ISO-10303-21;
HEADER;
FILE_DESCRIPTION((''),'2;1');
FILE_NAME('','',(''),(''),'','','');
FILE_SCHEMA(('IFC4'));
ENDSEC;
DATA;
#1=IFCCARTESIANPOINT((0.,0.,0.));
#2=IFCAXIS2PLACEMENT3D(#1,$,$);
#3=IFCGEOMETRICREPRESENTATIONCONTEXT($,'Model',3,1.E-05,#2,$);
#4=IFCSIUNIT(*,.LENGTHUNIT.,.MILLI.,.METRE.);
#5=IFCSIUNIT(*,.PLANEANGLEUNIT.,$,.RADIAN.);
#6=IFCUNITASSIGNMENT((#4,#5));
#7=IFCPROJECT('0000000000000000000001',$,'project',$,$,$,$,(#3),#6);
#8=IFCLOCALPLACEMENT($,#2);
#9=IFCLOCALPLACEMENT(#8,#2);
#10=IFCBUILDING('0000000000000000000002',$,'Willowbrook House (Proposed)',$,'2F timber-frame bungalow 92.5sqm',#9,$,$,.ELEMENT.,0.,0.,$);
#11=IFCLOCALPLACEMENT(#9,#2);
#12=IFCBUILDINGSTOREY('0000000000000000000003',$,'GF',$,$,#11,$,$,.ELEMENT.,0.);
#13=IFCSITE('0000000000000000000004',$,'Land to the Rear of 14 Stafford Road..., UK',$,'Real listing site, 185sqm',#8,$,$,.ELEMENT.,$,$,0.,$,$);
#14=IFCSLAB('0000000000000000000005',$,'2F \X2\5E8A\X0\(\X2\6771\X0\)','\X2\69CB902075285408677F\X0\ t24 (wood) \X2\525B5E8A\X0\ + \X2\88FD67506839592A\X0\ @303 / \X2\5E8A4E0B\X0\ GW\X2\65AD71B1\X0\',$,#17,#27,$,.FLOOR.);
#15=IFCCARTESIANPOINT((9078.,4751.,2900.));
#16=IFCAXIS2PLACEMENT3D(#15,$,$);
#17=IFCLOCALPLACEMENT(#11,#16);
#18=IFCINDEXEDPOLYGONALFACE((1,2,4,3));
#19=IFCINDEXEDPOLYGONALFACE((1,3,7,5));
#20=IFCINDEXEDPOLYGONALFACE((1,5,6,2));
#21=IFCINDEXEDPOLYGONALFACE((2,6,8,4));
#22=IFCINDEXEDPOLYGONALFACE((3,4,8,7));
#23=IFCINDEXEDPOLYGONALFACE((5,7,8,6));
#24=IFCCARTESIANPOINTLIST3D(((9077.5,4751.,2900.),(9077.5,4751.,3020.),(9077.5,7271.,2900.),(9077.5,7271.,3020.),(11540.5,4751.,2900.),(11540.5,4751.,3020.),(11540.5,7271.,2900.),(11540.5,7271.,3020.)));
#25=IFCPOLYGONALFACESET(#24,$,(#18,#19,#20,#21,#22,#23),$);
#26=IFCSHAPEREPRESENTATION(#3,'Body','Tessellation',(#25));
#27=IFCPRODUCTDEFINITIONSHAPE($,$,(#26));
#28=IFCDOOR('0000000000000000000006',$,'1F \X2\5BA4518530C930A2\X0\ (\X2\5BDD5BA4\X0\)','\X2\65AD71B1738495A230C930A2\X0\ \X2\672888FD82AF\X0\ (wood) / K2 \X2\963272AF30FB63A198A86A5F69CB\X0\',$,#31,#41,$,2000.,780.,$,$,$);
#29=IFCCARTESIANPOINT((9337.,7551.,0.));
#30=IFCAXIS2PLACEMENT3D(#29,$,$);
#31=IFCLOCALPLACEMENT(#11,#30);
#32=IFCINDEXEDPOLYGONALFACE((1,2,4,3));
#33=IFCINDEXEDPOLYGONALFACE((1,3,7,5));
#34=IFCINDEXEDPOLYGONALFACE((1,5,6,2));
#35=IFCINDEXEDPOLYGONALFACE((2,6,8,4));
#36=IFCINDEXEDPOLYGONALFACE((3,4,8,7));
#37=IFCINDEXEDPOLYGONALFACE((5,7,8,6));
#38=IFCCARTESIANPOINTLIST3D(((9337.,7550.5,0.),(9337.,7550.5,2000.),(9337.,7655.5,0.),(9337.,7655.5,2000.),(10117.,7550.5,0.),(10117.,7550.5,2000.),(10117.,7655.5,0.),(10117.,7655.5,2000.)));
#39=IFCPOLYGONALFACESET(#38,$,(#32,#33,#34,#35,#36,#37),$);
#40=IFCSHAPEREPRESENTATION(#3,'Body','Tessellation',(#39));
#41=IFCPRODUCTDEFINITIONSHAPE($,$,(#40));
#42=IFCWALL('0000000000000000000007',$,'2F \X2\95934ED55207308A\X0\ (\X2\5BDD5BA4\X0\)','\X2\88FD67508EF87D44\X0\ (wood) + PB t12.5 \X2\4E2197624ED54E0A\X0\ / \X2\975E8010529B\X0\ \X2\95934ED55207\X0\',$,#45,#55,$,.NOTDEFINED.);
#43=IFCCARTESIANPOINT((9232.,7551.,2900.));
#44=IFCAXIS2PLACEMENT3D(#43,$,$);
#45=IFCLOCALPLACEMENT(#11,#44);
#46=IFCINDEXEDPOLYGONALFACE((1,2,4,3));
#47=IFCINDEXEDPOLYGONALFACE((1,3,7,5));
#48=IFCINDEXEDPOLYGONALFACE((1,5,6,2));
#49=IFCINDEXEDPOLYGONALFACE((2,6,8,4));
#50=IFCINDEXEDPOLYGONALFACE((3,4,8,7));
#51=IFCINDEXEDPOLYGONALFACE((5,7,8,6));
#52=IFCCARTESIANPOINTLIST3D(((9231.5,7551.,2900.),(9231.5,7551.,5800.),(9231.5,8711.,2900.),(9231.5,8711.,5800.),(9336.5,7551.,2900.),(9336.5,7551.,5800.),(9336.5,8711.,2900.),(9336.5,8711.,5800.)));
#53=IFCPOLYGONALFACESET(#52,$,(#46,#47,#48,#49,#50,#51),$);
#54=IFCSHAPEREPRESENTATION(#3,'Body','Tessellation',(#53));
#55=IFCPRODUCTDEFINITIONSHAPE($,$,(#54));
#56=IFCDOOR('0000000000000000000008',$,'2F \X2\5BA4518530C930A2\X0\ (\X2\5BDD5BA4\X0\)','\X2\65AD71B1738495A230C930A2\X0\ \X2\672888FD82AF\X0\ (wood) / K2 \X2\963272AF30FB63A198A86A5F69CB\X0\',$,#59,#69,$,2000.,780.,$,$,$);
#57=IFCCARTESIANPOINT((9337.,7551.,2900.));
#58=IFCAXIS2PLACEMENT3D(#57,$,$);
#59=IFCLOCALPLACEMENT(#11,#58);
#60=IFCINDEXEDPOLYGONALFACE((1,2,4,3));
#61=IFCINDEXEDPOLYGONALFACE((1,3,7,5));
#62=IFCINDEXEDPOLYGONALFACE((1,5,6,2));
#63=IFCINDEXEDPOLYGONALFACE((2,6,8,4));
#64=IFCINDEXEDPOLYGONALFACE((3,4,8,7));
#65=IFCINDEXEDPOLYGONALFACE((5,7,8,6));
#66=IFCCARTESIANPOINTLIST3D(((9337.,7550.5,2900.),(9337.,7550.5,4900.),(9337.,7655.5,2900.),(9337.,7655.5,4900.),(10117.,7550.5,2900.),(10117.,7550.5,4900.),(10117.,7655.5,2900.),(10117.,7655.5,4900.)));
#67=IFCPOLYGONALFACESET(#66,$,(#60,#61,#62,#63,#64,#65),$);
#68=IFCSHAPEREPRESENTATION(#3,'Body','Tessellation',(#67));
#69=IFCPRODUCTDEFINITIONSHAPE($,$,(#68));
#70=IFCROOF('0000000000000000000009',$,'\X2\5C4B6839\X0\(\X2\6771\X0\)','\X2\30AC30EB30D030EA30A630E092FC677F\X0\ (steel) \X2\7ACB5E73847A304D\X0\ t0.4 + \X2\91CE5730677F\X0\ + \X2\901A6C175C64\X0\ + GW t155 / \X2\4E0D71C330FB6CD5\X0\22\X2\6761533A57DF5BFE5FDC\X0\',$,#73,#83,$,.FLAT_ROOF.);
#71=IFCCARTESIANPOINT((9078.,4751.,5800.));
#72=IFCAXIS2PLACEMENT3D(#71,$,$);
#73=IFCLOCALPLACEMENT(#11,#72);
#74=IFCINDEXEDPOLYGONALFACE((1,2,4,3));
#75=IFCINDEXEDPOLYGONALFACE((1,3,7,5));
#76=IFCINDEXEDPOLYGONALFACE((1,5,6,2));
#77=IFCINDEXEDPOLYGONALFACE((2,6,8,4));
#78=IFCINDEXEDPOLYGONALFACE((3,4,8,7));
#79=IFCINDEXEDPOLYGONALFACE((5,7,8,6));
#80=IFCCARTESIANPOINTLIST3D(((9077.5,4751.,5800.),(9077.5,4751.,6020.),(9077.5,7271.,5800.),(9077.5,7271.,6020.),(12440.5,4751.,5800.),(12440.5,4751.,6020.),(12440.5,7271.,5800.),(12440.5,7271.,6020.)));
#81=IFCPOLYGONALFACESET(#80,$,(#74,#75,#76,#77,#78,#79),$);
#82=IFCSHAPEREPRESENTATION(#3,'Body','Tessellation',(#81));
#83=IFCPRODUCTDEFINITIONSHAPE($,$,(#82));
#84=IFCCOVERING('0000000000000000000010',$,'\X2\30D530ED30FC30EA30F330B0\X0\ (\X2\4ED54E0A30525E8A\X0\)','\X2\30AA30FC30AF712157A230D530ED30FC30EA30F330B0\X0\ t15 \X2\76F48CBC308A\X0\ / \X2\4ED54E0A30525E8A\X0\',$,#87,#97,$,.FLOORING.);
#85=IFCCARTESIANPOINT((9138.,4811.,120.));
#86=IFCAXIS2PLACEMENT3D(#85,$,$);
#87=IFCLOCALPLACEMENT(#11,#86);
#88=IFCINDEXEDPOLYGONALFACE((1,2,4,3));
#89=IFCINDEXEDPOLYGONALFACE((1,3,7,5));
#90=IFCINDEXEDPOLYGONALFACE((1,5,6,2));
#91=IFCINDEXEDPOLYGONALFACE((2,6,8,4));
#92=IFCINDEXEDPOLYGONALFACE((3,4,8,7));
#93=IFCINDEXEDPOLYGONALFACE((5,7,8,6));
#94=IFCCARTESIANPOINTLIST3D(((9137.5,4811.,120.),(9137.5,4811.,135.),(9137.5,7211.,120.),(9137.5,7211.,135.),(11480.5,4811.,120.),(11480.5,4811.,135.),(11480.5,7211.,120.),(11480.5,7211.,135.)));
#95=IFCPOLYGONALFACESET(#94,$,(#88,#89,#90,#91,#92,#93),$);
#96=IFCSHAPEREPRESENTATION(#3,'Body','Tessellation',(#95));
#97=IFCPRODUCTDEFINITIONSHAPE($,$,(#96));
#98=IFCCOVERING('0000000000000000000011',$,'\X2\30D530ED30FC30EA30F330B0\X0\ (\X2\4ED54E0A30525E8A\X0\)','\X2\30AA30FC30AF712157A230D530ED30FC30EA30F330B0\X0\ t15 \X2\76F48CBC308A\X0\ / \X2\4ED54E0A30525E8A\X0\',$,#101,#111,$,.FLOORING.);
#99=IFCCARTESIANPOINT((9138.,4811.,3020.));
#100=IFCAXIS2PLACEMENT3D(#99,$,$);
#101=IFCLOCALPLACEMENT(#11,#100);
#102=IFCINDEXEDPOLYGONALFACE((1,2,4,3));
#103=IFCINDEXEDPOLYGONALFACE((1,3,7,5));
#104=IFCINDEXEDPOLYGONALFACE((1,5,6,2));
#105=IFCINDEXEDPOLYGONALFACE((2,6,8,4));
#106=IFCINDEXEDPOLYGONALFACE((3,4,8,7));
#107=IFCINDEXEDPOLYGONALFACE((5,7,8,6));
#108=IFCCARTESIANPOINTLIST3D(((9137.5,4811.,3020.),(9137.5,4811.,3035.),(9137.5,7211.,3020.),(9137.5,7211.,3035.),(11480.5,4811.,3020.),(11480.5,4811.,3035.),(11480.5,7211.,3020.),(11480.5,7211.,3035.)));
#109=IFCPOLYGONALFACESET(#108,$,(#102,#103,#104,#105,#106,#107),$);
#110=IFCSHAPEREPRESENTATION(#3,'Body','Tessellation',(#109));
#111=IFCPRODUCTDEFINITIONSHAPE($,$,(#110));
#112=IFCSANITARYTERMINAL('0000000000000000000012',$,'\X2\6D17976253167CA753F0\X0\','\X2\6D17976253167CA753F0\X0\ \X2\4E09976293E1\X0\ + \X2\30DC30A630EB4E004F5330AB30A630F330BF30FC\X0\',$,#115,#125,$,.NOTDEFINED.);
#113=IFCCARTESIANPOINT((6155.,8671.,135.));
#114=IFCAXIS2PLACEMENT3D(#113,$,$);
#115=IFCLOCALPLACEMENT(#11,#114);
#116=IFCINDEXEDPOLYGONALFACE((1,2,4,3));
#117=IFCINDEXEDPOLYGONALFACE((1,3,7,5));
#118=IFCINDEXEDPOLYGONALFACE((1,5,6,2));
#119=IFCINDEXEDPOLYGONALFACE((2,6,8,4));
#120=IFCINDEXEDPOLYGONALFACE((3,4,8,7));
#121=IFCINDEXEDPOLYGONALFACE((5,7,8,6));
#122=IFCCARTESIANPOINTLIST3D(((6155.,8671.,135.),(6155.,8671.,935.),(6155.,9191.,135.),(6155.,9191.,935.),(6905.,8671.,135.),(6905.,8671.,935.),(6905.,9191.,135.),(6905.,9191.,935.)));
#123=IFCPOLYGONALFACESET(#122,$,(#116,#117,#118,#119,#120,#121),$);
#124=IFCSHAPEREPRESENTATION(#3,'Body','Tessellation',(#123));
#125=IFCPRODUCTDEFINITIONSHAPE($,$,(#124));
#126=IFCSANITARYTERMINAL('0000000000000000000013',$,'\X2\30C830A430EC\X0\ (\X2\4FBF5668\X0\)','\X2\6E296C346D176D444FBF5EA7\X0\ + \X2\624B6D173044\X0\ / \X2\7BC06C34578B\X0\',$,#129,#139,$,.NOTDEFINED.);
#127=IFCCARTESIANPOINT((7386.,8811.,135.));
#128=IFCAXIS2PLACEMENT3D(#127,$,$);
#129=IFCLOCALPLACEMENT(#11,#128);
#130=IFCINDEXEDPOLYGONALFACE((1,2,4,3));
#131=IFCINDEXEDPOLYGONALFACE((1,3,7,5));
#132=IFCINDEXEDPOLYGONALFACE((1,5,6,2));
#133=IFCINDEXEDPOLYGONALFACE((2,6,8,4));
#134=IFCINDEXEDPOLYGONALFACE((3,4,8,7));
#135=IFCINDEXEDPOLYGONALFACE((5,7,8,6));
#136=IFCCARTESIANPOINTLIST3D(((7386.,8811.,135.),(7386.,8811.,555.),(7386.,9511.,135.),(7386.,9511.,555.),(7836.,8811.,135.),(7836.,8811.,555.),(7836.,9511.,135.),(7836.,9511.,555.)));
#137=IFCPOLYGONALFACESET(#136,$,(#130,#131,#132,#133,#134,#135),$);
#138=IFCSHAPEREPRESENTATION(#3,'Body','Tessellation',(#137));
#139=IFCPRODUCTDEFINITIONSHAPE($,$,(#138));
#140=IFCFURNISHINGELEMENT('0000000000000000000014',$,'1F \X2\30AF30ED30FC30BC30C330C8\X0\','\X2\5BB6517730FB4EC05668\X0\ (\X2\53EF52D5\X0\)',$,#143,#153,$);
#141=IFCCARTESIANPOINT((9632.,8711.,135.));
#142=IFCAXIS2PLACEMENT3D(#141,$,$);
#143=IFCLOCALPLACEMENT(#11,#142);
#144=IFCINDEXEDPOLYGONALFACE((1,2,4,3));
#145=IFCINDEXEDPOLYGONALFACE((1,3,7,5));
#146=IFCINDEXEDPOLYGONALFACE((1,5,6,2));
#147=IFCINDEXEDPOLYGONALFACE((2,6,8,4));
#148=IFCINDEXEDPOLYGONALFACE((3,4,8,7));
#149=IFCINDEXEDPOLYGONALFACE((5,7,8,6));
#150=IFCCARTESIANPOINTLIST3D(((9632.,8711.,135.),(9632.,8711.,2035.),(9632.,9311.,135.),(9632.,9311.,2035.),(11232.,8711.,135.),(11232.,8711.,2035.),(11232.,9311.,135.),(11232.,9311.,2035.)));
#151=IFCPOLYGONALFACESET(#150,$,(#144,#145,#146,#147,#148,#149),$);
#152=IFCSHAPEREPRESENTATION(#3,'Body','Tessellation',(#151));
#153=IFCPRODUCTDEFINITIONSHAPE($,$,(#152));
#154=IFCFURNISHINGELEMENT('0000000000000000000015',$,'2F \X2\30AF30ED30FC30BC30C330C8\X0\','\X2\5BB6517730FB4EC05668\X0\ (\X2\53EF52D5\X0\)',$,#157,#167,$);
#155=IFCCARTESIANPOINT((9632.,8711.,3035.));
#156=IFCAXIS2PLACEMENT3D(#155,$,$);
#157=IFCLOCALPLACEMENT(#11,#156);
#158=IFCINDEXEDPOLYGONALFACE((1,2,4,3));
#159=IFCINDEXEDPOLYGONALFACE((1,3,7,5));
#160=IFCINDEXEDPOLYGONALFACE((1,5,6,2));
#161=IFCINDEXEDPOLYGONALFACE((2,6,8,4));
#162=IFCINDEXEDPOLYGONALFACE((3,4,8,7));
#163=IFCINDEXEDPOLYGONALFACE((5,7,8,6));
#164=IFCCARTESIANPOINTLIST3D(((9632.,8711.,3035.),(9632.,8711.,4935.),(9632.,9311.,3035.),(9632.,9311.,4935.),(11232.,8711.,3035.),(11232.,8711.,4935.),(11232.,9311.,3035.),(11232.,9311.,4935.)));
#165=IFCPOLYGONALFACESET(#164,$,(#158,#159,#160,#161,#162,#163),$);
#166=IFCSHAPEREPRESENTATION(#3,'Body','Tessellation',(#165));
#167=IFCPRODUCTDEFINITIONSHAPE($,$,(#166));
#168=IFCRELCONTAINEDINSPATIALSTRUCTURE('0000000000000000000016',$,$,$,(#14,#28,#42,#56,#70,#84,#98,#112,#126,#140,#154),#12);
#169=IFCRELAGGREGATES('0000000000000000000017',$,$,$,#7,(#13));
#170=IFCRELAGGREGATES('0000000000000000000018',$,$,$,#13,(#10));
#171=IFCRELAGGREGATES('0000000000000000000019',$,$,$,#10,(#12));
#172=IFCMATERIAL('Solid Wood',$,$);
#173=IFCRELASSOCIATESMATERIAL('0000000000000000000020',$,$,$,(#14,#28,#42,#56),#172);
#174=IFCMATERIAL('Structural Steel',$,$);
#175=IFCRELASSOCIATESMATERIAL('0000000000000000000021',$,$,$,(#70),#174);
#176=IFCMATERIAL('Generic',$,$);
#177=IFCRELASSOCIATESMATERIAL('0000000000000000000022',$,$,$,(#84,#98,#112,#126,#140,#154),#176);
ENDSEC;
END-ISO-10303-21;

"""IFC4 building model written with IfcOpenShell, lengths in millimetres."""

from ifc_helpers import new_model, si_unit, frame, frame_2d, origin, place, context, project, spatial, rectangle, extrude, material, element, save


model = new_model("IFC4")

# Units and contexts
model_context = context("Model", 3, precision=1e-05, world=origin())
ifc_project = project(units=[si_unit("LENGTHUNIT", "METRE", prefix="MILLI"), si_unit("PLANEANGLEUNIT", "RADIAN")], contexts=[model_context])

# Site, building, storey
site_placement = place(None, origin())
site = spatial("IfcSite", under=ifc_project, at=site_placement, Name="Land to the Rear of 14 Stafford Road..., UK", ObjectType="Real listing site, 185sqm", CompositionType="ELEMENT", RefElevation=0.0)
building_placement = place(site_placement, origin())
building = spatial("IfcBuilding", under=site, at=building_placement, Name="Willowbrook House (Proposed)", ObjectType="2F timber-frame bungalow 92.5sqm", CompositionType="ELEMENT", ElevationOfRefHeight=0.0, ElevationOfTerrain=0.0)
storey_placement = place(building_placement, origin())
storey = spatial("IfcBuildingStorey", under=building, at=storey_placement, Name="GF", CompositionType="ELEMENT", Elevation=0.0)

# Slab
ifc_material_1 = material(Name="Solid Wood")
slab_1_placement = place(storey_placement, frame((9078.0, 4751.0, 2900.0)))
element("IfcSlab", 1, at=slab_1_placement, inside=storey, material=ifc_material_1, Name="2F 床(東)", Description="構造用合板 t24 (wood) 剛床 + 製材根太 @303 / 床下 GW断熱", PredefinedType="FLOOR", context=model_context, shape_type="SweptSolid", body=[
    extrude(rectangle(XDim=2463.0, YDim=2520.0, at=frame_2d((1231.0, 1260.0))), frame((9078.0, 4751.0, 2900.0)), (0.0, 0.0, 1.0), 120.0),
])

# Door
door_1_placement = place(storey_placement, frame((9337.0, 7551.0, 0.0)))
element("IfcDoor", 2, at=door_1_placement, inside=storey, material=ifc_material_1, Name="1F 室内ドア (寝室)", Description="断熱玄関ドア 木製芯 (wood) / K2 防犯・採風機構", OverallHeight=2000.0, OverallWidth=780.0, context=model_context, shape_type="SweptSolid", body=[
    extrude(rectangle(XDim=780.0, YDim=105.0, at=frame_2d((390.0, 52.0))), frame((9337.0, 7551.0, 0.0)), (0.0, 0.0, 1.0), 2000.0),
])

# Wall
wall_1_placement = place(storey_placement, frame((9232.0, 7551.0, 2900.0)))
element("IfcWall", 3, at=wall_1_placement, inside=storey, material=ifc_material_1, Name="2F 間仕切り (寝室)", Description="製材軸組 (wood) + PB t12.5 両面仕上 / 非耐力 間仕切", PredefinedType="NOTDEFINED", context=model_context, shape_type="SweptSolid", body=[
    extrude(rectangle(XDim=105.0, YDim=1160.0, at=frame_2d((52.0, 580.0))), frame((9232.0, 7551.0, 2900.0)), (0.0, 0.0, 1.0), 2900.0),
])

# Door
door_2_placement = place(storey_placement, frame((9337.0, 7551.0, 2900.0)))
element("IfcDoor", 4, at=door_2_placement, inside=storey, material=ifc_material_1, Name="2F 室内ドア (寝室)", Description="断熱玄関ドア 木製芯 (wood) / K2 防犯・採風機構", OverallHeight=2000.0, OverallWidth=780.0, context=model_context, shape_type="SweptSolid", body=[
    extrude(rectangle(XDim=780.0, YDim=105.0, at=frame_2d((390.0, 52.0))), frame((9337.0, 7551.0, 2900.0)), (0.0, 0.0, 1.0), 2000.0),
])

# Roof
ifc_material_2 = material(Name="Structural Steel")
for number, where, name in (
    (5, (9078.0, 4751.0, 5800.0), "屋根(東)"),
):
    element("IfcRoof", number, at=place(storey_placement, frame(where)), inside=storey, material=ifc_material_2, Name=name, Description="ガルバリウム鋼板 (steel) 立平葺き t0.4 + 野地板 + 通気層 + GW t155 / 不燃・法22条区域対応", PredefinedType="FLAT_ROOF", context=model_context, shape_type="SweptSolid", body=[
        extrude(rectangle(XDim=3363.0, YDim=2520.0, at=frame_2d((1681.0, 1260.0))), frame((9078.0, 4751.0, 5800.0)), (0.0, 0.0, 1.0), 220.0),
    ])

# Coverings
ifc_material_3 = material(Name="Generic")
covering_1_placement = place(storey_placement, frame((9138.0, 4811.0, 120.0)))
element("IfcCovering", 6, at=covering_1_placement, inside=storey, material=ifc_material_3, Name="フローリング (仕上げ床)", Description="オーク無垢フローリング t15 直貼り / 仕上げ床", PredefinedType="FLOORING", context=model_context, shape_type="SweptSolid", body=[
    extrude(rectangle(XDim=2343.0, YDim=2400.0, at=frame_2d((1171.0, 1200.0))), frame((9138.0, 4811.0, 120.0)), (0.0, 0.0, 1.0), 15.0),
])
covering_2_placement = place(storey_placement, frame((9138.0, 4811.0, 3020.0)))
element("IfcCovering", 7, at=covering_2_placement, inside=storey, material=ifc_material_3, Name="フローリング (仕上げ床)", Description="オーク無垢フローリング t15 直貼り / 仕上げ床", PredefinedType="FLOORING", context=model_context, shape_type="SweptSolid", body=[
    extrude(rectangle(XDim=2343.0, YDim=2400.0, at=frame_2d((1171.0, 1200.0))), frame((9138.0, 4811.0, 3020.0)), (0.0, 0.0, 1.0), 15.0),
])

# Sanitary terminals
sanitary_terminal_1_placement = place(storey_placement, frame((6155.0, 8671.0, 135.0)))
element("IfcSanitaryTerminal", 8, at=sanitary_terminal_1_placement, inside=storey, material=ifc_material_3, Name="洗面化粧台", Description="洗面化粧台 三面鏡 + ボウル一体カウンター", PredefinedType="NOTDEFINED", context=model_context, shape_type="SweptSolid", body=[
    extrude(rectangle(XDim=750.0, YDim=520.0, at=frame_2d((375.0, 260.0))), frame((6155.0, 8671.0, 135.0)), (0.0, 0.0, 1.0), 800.0),
])
sanitary_terminal_2_placement = place(storey_placement, frame((7386.0, 8811.0, 135.0)))
element("IfcSanitaryTerminal", 9, at=sanitary_terminal_2_placement, inside=storey, material=ifc_material_3, Name="トイレ (便器)", Description="温水洗浄便座 + 手洗い / 節水型", PredefinedType="NOTDEFINED", context=model_context, shape_type="SweptSolid", body=[
    extrude(rectangle(XDim=450.0, YDim=700.0, at=frame_2d((225.0, 350.0))), frame((7386.0, 8811.0, 135.0)), (0.0, 0.0, 1.0), 420.0),
])

# Furnishing elements
furnishing_1_placement = place(storey_placement, frame((9632.0, 8711.0, 135.0)))
element("IfcFurnishingElement", 10, at=furnishing_1_placement, inside=storey, material=ifc_material_3, Name="1F クローゼット", Description="家具・什器 (可動)", context=model_context, shape_type="SweptSolid", body=[
    extrude(rectangle(XDim=1600.0, YDim=600.0, at=frame_2d((800.0, 300.0))), frame((9632.0, 8711.0, 135.0)), (0.0, 0.0, 1.0), 1900.0),
])
furnishing_2_placement = place(storey_placement, frame((9632.0, 8711.0, 3035.0)))
element("IfcFurnishingElement", 11, at=furnishing_2_placement, inside=storey, material=ifc_material_3, Name="2F クローゼット", Description="家具・什器 (可動)", context=model_context, shape_type="SweptSolid", body=[
    extrude(rectangle(XDim=1600.0, YDim=600.0, at=frame_2d((800.0, 300.0))), frame((9632.0, 8711.0, 3035.0)), (0.0, 0.0, 1.0), 1900.0),
])

save(model, "model.ifc")
